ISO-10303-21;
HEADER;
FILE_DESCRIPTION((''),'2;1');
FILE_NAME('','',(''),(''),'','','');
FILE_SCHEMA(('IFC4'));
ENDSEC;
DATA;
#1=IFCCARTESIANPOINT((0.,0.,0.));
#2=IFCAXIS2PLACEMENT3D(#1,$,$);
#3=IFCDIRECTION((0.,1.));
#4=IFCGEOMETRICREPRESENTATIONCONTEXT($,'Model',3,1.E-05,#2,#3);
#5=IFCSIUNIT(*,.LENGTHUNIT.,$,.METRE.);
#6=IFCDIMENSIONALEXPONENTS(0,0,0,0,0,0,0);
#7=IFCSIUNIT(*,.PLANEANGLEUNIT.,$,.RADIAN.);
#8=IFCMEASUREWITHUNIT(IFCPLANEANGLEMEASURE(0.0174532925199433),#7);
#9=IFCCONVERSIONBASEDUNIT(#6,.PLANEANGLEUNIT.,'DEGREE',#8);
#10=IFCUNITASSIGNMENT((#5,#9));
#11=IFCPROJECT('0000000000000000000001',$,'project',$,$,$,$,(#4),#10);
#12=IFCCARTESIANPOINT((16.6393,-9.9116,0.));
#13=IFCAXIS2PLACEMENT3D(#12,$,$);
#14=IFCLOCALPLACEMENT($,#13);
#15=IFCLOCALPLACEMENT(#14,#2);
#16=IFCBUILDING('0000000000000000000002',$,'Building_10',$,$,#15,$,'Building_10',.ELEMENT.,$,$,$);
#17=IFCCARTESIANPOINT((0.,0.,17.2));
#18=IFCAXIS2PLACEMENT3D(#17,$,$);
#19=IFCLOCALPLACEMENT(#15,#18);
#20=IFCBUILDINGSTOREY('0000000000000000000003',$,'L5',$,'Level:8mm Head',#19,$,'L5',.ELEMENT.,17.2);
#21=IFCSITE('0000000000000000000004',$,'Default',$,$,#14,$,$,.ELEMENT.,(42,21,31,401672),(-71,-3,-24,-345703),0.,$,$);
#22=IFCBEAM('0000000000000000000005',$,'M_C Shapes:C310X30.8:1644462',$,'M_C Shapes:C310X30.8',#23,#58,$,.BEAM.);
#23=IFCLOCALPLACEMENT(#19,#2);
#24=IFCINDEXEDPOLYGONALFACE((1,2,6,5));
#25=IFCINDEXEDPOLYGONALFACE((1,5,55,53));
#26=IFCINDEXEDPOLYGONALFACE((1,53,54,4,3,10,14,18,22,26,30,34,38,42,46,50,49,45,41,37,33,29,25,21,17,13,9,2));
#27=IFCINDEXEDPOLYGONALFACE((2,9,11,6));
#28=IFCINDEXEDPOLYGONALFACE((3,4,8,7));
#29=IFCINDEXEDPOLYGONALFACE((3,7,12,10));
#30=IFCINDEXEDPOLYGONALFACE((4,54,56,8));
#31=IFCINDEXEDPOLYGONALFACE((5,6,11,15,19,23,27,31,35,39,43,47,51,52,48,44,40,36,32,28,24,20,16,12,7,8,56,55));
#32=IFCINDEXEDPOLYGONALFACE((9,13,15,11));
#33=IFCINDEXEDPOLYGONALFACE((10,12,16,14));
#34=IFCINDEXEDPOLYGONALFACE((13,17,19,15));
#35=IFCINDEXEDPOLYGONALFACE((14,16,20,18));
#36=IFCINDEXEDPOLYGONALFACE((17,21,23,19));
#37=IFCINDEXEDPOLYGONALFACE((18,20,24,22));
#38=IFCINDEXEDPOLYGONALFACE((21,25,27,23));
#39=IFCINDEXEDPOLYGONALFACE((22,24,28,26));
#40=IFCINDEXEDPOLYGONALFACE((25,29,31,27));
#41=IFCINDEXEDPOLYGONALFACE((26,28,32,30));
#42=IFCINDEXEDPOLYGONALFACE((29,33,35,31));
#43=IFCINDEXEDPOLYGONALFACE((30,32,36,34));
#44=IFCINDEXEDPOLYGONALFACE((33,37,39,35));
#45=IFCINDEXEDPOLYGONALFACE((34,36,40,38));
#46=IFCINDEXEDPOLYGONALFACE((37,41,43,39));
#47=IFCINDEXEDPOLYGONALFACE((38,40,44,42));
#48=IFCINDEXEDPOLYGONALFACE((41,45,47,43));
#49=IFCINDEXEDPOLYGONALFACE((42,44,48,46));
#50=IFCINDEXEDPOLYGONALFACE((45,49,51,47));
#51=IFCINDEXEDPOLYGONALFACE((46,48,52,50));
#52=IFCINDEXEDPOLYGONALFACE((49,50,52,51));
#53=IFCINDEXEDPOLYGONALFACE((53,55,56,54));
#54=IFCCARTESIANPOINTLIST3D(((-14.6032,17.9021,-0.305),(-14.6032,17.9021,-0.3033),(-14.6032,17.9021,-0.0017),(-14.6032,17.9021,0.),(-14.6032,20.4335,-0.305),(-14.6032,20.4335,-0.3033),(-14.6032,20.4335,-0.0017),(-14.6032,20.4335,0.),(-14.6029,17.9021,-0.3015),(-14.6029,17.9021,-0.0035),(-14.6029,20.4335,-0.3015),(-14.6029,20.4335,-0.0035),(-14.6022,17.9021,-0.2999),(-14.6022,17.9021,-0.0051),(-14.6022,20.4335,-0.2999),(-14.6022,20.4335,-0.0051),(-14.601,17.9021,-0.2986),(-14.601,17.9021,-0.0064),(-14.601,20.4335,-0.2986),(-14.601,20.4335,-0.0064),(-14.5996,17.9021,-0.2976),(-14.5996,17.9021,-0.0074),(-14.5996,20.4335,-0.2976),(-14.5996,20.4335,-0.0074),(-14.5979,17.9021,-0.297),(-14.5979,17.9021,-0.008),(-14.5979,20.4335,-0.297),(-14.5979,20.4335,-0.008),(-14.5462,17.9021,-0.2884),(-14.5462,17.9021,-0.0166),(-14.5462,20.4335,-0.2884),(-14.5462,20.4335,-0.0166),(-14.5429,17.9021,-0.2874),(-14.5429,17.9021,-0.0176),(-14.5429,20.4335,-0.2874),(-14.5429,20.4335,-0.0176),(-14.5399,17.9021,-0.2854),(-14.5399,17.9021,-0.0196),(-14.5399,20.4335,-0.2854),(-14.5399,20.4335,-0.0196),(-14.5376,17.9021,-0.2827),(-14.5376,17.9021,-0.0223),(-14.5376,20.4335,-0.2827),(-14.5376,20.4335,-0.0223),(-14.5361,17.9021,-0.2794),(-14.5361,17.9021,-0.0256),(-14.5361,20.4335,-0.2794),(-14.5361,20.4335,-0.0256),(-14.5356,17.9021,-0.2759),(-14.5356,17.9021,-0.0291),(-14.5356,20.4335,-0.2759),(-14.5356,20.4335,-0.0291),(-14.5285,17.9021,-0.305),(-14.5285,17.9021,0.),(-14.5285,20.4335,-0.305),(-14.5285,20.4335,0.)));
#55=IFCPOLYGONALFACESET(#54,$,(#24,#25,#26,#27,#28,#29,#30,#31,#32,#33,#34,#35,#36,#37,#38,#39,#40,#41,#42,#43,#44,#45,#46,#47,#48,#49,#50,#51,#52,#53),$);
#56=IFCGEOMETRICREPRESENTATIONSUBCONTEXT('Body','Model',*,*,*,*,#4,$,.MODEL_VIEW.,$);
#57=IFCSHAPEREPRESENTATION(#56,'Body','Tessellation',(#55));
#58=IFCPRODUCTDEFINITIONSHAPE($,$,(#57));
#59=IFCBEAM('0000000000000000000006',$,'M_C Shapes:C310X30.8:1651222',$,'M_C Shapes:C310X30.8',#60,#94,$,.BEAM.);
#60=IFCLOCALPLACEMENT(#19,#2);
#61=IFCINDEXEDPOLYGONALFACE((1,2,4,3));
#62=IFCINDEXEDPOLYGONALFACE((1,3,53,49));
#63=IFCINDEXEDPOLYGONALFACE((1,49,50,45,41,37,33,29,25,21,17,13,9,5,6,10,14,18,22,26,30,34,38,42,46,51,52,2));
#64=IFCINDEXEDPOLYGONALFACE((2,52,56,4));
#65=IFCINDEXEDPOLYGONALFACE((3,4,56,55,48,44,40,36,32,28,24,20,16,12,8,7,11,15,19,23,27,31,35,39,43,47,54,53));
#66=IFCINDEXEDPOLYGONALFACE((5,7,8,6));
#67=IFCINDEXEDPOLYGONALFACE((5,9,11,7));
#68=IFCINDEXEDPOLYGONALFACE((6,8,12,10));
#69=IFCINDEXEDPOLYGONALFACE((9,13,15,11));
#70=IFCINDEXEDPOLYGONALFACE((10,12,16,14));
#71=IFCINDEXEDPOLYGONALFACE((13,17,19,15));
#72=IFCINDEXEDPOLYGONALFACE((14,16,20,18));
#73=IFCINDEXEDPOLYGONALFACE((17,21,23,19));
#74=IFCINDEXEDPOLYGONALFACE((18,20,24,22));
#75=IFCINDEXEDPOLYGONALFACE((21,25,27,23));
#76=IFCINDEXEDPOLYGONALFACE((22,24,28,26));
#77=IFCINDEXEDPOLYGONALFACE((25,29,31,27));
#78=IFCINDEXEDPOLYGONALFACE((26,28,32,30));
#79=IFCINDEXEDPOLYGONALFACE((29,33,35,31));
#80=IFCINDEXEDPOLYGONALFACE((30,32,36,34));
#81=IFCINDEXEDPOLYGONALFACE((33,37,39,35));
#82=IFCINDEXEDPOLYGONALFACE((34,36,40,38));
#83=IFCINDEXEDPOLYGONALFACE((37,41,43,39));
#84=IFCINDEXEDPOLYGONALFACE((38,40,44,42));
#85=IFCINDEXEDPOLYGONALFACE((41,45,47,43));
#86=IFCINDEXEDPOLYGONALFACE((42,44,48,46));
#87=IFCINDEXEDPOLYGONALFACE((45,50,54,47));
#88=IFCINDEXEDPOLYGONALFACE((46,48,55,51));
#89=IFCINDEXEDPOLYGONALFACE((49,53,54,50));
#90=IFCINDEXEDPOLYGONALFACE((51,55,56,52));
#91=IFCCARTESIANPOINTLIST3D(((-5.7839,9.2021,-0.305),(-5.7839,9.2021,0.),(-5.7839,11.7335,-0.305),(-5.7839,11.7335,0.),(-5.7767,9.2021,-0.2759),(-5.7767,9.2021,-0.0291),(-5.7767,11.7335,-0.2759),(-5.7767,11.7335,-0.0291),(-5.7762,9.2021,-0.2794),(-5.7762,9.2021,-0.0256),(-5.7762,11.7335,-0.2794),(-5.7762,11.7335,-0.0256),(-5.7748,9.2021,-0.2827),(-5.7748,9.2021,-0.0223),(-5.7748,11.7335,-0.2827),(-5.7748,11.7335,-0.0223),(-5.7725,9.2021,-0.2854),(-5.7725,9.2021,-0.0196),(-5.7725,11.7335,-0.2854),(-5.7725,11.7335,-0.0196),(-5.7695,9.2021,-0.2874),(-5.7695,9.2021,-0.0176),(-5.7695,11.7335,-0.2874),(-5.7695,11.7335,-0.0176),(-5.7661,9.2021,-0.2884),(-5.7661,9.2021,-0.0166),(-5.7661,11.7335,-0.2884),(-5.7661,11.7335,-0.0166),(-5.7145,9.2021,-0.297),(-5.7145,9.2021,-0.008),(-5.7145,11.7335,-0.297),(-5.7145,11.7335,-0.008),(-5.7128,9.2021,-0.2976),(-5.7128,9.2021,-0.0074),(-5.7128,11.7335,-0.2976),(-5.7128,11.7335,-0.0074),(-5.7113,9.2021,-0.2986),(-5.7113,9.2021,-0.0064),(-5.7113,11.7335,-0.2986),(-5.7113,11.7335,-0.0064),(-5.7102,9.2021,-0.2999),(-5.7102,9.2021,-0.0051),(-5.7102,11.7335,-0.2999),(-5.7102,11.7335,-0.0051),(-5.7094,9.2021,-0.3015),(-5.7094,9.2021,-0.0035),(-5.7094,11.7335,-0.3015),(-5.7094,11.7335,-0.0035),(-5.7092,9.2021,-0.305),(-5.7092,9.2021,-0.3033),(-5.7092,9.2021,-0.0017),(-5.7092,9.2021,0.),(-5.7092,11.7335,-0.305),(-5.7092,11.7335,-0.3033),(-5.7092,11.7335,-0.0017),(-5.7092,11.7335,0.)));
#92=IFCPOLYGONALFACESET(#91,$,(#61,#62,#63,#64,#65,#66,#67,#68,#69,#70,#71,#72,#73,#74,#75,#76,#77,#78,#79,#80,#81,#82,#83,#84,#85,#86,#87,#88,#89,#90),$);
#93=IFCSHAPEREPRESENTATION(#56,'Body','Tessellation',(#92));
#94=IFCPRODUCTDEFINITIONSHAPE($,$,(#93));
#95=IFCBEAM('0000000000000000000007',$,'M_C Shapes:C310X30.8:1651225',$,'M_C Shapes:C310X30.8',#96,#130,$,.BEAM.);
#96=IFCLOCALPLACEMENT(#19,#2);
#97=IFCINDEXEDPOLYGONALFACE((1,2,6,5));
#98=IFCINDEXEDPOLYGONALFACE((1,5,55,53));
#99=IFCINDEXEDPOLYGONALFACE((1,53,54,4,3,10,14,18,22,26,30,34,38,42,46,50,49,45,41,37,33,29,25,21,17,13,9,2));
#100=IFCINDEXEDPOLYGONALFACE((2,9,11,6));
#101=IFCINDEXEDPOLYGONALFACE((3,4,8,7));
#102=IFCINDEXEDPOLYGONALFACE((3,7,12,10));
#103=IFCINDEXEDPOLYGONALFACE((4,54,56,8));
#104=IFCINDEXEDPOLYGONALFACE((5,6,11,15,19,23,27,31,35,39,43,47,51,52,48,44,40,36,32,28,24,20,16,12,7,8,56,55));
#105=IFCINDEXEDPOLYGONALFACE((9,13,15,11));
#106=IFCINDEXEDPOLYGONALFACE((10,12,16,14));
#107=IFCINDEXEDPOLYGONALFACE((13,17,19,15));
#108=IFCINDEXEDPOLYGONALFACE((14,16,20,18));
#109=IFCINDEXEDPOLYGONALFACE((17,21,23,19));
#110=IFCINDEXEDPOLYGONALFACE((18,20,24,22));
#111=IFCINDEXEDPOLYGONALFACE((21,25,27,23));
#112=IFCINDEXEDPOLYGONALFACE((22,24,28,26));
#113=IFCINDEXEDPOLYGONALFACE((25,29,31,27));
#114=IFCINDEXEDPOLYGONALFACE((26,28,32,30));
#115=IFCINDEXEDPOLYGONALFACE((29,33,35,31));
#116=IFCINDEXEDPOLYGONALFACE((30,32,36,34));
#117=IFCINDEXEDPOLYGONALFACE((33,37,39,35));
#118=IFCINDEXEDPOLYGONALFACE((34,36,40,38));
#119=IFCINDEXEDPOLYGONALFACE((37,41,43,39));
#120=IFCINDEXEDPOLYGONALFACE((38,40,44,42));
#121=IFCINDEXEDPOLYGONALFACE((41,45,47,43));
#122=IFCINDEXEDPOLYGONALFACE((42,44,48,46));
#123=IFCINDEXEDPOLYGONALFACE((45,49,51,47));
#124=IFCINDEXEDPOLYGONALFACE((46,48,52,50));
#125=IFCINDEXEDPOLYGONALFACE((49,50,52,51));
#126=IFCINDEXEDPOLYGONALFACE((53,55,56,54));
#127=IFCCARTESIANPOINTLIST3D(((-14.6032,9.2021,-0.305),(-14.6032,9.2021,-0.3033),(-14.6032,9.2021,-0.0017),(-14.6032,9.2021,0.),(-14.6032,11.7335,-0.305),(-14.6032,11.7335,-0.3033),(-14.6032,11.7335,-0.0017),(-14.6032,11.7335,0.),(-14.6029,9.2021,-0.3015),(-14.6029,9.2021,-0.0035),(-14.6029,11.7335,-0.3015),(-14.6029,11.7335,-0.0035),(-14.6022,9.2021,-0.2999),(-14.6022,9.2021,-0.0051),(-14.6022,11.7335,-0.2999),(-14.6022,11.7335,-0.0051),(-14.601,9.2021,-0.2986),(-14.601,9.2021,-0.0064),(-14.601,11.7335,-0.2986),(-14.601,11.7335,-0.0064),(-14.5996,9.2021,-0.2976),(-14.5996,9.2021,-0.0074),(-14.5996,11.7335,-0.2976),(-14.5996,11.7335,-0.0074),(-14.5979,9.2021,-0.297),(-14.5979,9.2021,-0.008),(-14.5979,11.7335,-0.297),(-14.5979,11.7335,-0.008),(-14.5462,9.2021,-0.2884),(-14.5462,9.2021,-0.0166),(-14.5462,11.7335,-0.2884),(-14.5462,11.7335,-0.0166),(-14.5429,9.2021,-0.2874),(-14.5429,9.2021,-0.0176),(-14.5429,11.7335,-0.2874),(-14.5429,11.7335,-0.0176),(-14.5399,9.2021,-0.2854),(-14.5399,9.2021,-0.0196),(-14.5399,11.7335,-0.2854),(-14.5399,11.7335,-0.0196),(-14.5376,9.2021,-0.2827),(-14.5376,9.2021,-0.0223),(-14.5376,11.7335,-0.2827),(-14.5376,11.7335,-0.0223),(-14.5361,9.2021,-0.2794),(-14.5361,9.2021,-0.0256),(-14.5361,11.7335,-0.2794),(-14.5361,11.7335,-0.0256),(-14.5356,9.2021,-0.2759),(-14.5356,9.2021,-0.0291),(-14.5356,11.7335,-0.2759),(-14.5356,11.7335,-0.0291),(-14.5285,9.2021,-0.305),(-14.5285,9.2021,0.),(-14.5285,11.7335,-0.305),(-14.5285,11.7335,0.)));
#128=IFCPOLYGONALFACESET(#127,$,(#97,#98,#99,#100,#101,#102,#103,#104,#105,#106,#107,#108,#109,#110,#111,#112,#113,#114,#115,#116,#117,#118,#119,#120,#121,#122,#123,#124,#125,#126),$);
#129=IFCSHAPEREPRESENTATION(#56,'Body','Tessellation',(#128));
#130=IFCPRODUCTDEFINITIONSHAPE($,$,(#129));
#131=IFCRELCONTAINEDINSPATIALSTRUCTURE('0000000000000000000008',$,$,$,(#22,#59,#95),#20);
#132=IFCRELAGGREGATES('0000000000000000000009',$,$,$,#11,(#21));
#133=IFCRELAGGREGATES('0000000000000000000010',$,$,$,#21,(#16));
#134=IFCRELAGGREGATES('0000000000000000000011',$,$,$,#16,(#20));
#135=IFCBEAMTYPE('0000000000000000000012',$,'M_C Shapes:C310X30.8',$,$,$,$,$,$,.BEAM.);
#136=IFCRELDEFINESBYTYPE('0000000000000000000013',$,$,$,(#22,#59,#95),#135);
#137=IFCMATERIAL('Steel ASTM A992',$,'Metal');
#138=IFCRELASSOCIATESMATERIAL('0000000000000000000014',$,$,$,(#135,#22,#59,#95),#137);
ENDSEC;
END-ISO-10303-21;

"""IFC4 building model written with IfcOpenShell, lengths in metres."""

from ifc_helpers import new_model, entity, si_unit, converted_unit, direction, frame, origin, place, context, subcontext, project, spatial, line, arc, indexed_curve, outline, extrude, source, transform, mapped, material, type_object, type_shapes, element, save


model = new_model("IFC4")

# Units and contexts
model_context = context("Model", 3, precision=1e-05, world=origin(), true_north=direction((0.0, 1.0)))
body_context = subcontext(model_context, "Body", "Model", "MODEL_VIEW")
ifc_project = project(units=[si_unit("LENGTHUNIT", "METRE"), converted_unit("PLANEANGLEUNIT", "DEGREE", entity("IfcPlaneAngleMeasure", 0.0174532925199433), si_unit("PLANEANGLEUNIT", "RADIAN"), dimensions=[0, 0, 0, 0, 0, 0, 0])], contexts=[model_context])

# Site, building, storey
site_placement = place(None, frame((16.6393, -9.9116, 0.0)))
site = spatial("IfcSite", under=ifc_project, at=site_placement, Name="Default", CompositionType="ELEMENT", RefLatitude=(42, 21, 31, 401672), RefLongitude=(-71, -3, -24, -345703), RefElevation=0.0)
building_placement = place(site_placement, origin())
building = spatial("IfcBuilding", under=site, at=building_placement, Name="Building_10", LongName="Building_10", CompositionType="ELEMENT")
storey_placement = place(building_placement, frame((0.0, 0.0, 17.2)))
storey = spatial("IfcBuildingStorey", under=building, at=storey_placement, Name="L5", ObjectType="Level:8mm Head", LongName="L5", CompositionType="ELEMENT", Elevation=17.2)

# Shared definitions
ifc_material = material(Name="Steel ASTM A992", Category="Metal")

# Beams
beam_type_1 = type_object("IfcBeamType", Name="M_C Shapes:C310X30.8", PredefinedType="BEAM", material=ifc_material)
shared_shape_1 = source(origin(), body_context, "Body", "SweptSolid", [
    extrude(outline(indexed_curve([(-0.0406, -0.1525), (0.0341, -0.1525), (0.0341, -0.1508), (0.0326, -0.1467), (0.0288, -0.1445), (-0.0228, -0.1359), (-0.0305, -0.1316), (-0.0335, -0.1234), (-0.0335, 0.1234), (-0.0305, 0.1316), (-0.0228, 0.1359), (0.0288, 0.1445), (0.0326, 0.1467), (0.0341, 0.1508), (0.0341, 0.1525), (-0.0406, 0.1525)], segments=[line(1, 2, 3), arc(3, 4, 5), line(5, 6), arc(6, 7, 8), line(8, 9), arc(9, 10, 11), line(11, 12), arc(12, 13, 14), line(14, 15, 16, 1)], self_intersect=False)), frame((-1.2657, -0.0229, 0.0), z_axis=(1.0, 0.0, 0.0), x_axis=(0.0, -1.0, 0.0)), (0.0, 0.0, 1.0), 2.5314),
])
type_shapes(beam_type_1, [shared_shape_1])
for number, where, z_axis, x_axis, name in (
    (1, (-14.5462, 19.1678, -0.1525), (0.0, 0.0, 1.0), (0.0, -1.0, 0.0), "M_C Shapes:C310X30.8:1644462"),
    (2, (-5.7662, 10.4678, -0.1525), (0.0, 0.0, 1.0), (0.0, 1.0, 0.0), "M_C Shapes:C310X30.8:1651222"),
    (3, (-14.5462, 10.4678, -0.1525), (0.0, 0.0, 1.0), (0.0, -1.0, 0.0), "M_C Shapes:C310X30.8:1651225"),
):
    element("IfcBeam", number, at=place(storey_placement, frame(where, z_axis=z_axis, x_axis=x_axis)), inside=storey, type_object=beam_type_1, material=ifc_material, Name=name, ObjectType="M_C Shapes:C310X30.8", PredefinedType="BEAM", context=body_context, shape_type="MappedRepresentation", body=[
        mapped(shared_shape_1, transform((0.0, 0.0, 0.0), scale=1.0)),
    ])

save(model, "model.ifc")
